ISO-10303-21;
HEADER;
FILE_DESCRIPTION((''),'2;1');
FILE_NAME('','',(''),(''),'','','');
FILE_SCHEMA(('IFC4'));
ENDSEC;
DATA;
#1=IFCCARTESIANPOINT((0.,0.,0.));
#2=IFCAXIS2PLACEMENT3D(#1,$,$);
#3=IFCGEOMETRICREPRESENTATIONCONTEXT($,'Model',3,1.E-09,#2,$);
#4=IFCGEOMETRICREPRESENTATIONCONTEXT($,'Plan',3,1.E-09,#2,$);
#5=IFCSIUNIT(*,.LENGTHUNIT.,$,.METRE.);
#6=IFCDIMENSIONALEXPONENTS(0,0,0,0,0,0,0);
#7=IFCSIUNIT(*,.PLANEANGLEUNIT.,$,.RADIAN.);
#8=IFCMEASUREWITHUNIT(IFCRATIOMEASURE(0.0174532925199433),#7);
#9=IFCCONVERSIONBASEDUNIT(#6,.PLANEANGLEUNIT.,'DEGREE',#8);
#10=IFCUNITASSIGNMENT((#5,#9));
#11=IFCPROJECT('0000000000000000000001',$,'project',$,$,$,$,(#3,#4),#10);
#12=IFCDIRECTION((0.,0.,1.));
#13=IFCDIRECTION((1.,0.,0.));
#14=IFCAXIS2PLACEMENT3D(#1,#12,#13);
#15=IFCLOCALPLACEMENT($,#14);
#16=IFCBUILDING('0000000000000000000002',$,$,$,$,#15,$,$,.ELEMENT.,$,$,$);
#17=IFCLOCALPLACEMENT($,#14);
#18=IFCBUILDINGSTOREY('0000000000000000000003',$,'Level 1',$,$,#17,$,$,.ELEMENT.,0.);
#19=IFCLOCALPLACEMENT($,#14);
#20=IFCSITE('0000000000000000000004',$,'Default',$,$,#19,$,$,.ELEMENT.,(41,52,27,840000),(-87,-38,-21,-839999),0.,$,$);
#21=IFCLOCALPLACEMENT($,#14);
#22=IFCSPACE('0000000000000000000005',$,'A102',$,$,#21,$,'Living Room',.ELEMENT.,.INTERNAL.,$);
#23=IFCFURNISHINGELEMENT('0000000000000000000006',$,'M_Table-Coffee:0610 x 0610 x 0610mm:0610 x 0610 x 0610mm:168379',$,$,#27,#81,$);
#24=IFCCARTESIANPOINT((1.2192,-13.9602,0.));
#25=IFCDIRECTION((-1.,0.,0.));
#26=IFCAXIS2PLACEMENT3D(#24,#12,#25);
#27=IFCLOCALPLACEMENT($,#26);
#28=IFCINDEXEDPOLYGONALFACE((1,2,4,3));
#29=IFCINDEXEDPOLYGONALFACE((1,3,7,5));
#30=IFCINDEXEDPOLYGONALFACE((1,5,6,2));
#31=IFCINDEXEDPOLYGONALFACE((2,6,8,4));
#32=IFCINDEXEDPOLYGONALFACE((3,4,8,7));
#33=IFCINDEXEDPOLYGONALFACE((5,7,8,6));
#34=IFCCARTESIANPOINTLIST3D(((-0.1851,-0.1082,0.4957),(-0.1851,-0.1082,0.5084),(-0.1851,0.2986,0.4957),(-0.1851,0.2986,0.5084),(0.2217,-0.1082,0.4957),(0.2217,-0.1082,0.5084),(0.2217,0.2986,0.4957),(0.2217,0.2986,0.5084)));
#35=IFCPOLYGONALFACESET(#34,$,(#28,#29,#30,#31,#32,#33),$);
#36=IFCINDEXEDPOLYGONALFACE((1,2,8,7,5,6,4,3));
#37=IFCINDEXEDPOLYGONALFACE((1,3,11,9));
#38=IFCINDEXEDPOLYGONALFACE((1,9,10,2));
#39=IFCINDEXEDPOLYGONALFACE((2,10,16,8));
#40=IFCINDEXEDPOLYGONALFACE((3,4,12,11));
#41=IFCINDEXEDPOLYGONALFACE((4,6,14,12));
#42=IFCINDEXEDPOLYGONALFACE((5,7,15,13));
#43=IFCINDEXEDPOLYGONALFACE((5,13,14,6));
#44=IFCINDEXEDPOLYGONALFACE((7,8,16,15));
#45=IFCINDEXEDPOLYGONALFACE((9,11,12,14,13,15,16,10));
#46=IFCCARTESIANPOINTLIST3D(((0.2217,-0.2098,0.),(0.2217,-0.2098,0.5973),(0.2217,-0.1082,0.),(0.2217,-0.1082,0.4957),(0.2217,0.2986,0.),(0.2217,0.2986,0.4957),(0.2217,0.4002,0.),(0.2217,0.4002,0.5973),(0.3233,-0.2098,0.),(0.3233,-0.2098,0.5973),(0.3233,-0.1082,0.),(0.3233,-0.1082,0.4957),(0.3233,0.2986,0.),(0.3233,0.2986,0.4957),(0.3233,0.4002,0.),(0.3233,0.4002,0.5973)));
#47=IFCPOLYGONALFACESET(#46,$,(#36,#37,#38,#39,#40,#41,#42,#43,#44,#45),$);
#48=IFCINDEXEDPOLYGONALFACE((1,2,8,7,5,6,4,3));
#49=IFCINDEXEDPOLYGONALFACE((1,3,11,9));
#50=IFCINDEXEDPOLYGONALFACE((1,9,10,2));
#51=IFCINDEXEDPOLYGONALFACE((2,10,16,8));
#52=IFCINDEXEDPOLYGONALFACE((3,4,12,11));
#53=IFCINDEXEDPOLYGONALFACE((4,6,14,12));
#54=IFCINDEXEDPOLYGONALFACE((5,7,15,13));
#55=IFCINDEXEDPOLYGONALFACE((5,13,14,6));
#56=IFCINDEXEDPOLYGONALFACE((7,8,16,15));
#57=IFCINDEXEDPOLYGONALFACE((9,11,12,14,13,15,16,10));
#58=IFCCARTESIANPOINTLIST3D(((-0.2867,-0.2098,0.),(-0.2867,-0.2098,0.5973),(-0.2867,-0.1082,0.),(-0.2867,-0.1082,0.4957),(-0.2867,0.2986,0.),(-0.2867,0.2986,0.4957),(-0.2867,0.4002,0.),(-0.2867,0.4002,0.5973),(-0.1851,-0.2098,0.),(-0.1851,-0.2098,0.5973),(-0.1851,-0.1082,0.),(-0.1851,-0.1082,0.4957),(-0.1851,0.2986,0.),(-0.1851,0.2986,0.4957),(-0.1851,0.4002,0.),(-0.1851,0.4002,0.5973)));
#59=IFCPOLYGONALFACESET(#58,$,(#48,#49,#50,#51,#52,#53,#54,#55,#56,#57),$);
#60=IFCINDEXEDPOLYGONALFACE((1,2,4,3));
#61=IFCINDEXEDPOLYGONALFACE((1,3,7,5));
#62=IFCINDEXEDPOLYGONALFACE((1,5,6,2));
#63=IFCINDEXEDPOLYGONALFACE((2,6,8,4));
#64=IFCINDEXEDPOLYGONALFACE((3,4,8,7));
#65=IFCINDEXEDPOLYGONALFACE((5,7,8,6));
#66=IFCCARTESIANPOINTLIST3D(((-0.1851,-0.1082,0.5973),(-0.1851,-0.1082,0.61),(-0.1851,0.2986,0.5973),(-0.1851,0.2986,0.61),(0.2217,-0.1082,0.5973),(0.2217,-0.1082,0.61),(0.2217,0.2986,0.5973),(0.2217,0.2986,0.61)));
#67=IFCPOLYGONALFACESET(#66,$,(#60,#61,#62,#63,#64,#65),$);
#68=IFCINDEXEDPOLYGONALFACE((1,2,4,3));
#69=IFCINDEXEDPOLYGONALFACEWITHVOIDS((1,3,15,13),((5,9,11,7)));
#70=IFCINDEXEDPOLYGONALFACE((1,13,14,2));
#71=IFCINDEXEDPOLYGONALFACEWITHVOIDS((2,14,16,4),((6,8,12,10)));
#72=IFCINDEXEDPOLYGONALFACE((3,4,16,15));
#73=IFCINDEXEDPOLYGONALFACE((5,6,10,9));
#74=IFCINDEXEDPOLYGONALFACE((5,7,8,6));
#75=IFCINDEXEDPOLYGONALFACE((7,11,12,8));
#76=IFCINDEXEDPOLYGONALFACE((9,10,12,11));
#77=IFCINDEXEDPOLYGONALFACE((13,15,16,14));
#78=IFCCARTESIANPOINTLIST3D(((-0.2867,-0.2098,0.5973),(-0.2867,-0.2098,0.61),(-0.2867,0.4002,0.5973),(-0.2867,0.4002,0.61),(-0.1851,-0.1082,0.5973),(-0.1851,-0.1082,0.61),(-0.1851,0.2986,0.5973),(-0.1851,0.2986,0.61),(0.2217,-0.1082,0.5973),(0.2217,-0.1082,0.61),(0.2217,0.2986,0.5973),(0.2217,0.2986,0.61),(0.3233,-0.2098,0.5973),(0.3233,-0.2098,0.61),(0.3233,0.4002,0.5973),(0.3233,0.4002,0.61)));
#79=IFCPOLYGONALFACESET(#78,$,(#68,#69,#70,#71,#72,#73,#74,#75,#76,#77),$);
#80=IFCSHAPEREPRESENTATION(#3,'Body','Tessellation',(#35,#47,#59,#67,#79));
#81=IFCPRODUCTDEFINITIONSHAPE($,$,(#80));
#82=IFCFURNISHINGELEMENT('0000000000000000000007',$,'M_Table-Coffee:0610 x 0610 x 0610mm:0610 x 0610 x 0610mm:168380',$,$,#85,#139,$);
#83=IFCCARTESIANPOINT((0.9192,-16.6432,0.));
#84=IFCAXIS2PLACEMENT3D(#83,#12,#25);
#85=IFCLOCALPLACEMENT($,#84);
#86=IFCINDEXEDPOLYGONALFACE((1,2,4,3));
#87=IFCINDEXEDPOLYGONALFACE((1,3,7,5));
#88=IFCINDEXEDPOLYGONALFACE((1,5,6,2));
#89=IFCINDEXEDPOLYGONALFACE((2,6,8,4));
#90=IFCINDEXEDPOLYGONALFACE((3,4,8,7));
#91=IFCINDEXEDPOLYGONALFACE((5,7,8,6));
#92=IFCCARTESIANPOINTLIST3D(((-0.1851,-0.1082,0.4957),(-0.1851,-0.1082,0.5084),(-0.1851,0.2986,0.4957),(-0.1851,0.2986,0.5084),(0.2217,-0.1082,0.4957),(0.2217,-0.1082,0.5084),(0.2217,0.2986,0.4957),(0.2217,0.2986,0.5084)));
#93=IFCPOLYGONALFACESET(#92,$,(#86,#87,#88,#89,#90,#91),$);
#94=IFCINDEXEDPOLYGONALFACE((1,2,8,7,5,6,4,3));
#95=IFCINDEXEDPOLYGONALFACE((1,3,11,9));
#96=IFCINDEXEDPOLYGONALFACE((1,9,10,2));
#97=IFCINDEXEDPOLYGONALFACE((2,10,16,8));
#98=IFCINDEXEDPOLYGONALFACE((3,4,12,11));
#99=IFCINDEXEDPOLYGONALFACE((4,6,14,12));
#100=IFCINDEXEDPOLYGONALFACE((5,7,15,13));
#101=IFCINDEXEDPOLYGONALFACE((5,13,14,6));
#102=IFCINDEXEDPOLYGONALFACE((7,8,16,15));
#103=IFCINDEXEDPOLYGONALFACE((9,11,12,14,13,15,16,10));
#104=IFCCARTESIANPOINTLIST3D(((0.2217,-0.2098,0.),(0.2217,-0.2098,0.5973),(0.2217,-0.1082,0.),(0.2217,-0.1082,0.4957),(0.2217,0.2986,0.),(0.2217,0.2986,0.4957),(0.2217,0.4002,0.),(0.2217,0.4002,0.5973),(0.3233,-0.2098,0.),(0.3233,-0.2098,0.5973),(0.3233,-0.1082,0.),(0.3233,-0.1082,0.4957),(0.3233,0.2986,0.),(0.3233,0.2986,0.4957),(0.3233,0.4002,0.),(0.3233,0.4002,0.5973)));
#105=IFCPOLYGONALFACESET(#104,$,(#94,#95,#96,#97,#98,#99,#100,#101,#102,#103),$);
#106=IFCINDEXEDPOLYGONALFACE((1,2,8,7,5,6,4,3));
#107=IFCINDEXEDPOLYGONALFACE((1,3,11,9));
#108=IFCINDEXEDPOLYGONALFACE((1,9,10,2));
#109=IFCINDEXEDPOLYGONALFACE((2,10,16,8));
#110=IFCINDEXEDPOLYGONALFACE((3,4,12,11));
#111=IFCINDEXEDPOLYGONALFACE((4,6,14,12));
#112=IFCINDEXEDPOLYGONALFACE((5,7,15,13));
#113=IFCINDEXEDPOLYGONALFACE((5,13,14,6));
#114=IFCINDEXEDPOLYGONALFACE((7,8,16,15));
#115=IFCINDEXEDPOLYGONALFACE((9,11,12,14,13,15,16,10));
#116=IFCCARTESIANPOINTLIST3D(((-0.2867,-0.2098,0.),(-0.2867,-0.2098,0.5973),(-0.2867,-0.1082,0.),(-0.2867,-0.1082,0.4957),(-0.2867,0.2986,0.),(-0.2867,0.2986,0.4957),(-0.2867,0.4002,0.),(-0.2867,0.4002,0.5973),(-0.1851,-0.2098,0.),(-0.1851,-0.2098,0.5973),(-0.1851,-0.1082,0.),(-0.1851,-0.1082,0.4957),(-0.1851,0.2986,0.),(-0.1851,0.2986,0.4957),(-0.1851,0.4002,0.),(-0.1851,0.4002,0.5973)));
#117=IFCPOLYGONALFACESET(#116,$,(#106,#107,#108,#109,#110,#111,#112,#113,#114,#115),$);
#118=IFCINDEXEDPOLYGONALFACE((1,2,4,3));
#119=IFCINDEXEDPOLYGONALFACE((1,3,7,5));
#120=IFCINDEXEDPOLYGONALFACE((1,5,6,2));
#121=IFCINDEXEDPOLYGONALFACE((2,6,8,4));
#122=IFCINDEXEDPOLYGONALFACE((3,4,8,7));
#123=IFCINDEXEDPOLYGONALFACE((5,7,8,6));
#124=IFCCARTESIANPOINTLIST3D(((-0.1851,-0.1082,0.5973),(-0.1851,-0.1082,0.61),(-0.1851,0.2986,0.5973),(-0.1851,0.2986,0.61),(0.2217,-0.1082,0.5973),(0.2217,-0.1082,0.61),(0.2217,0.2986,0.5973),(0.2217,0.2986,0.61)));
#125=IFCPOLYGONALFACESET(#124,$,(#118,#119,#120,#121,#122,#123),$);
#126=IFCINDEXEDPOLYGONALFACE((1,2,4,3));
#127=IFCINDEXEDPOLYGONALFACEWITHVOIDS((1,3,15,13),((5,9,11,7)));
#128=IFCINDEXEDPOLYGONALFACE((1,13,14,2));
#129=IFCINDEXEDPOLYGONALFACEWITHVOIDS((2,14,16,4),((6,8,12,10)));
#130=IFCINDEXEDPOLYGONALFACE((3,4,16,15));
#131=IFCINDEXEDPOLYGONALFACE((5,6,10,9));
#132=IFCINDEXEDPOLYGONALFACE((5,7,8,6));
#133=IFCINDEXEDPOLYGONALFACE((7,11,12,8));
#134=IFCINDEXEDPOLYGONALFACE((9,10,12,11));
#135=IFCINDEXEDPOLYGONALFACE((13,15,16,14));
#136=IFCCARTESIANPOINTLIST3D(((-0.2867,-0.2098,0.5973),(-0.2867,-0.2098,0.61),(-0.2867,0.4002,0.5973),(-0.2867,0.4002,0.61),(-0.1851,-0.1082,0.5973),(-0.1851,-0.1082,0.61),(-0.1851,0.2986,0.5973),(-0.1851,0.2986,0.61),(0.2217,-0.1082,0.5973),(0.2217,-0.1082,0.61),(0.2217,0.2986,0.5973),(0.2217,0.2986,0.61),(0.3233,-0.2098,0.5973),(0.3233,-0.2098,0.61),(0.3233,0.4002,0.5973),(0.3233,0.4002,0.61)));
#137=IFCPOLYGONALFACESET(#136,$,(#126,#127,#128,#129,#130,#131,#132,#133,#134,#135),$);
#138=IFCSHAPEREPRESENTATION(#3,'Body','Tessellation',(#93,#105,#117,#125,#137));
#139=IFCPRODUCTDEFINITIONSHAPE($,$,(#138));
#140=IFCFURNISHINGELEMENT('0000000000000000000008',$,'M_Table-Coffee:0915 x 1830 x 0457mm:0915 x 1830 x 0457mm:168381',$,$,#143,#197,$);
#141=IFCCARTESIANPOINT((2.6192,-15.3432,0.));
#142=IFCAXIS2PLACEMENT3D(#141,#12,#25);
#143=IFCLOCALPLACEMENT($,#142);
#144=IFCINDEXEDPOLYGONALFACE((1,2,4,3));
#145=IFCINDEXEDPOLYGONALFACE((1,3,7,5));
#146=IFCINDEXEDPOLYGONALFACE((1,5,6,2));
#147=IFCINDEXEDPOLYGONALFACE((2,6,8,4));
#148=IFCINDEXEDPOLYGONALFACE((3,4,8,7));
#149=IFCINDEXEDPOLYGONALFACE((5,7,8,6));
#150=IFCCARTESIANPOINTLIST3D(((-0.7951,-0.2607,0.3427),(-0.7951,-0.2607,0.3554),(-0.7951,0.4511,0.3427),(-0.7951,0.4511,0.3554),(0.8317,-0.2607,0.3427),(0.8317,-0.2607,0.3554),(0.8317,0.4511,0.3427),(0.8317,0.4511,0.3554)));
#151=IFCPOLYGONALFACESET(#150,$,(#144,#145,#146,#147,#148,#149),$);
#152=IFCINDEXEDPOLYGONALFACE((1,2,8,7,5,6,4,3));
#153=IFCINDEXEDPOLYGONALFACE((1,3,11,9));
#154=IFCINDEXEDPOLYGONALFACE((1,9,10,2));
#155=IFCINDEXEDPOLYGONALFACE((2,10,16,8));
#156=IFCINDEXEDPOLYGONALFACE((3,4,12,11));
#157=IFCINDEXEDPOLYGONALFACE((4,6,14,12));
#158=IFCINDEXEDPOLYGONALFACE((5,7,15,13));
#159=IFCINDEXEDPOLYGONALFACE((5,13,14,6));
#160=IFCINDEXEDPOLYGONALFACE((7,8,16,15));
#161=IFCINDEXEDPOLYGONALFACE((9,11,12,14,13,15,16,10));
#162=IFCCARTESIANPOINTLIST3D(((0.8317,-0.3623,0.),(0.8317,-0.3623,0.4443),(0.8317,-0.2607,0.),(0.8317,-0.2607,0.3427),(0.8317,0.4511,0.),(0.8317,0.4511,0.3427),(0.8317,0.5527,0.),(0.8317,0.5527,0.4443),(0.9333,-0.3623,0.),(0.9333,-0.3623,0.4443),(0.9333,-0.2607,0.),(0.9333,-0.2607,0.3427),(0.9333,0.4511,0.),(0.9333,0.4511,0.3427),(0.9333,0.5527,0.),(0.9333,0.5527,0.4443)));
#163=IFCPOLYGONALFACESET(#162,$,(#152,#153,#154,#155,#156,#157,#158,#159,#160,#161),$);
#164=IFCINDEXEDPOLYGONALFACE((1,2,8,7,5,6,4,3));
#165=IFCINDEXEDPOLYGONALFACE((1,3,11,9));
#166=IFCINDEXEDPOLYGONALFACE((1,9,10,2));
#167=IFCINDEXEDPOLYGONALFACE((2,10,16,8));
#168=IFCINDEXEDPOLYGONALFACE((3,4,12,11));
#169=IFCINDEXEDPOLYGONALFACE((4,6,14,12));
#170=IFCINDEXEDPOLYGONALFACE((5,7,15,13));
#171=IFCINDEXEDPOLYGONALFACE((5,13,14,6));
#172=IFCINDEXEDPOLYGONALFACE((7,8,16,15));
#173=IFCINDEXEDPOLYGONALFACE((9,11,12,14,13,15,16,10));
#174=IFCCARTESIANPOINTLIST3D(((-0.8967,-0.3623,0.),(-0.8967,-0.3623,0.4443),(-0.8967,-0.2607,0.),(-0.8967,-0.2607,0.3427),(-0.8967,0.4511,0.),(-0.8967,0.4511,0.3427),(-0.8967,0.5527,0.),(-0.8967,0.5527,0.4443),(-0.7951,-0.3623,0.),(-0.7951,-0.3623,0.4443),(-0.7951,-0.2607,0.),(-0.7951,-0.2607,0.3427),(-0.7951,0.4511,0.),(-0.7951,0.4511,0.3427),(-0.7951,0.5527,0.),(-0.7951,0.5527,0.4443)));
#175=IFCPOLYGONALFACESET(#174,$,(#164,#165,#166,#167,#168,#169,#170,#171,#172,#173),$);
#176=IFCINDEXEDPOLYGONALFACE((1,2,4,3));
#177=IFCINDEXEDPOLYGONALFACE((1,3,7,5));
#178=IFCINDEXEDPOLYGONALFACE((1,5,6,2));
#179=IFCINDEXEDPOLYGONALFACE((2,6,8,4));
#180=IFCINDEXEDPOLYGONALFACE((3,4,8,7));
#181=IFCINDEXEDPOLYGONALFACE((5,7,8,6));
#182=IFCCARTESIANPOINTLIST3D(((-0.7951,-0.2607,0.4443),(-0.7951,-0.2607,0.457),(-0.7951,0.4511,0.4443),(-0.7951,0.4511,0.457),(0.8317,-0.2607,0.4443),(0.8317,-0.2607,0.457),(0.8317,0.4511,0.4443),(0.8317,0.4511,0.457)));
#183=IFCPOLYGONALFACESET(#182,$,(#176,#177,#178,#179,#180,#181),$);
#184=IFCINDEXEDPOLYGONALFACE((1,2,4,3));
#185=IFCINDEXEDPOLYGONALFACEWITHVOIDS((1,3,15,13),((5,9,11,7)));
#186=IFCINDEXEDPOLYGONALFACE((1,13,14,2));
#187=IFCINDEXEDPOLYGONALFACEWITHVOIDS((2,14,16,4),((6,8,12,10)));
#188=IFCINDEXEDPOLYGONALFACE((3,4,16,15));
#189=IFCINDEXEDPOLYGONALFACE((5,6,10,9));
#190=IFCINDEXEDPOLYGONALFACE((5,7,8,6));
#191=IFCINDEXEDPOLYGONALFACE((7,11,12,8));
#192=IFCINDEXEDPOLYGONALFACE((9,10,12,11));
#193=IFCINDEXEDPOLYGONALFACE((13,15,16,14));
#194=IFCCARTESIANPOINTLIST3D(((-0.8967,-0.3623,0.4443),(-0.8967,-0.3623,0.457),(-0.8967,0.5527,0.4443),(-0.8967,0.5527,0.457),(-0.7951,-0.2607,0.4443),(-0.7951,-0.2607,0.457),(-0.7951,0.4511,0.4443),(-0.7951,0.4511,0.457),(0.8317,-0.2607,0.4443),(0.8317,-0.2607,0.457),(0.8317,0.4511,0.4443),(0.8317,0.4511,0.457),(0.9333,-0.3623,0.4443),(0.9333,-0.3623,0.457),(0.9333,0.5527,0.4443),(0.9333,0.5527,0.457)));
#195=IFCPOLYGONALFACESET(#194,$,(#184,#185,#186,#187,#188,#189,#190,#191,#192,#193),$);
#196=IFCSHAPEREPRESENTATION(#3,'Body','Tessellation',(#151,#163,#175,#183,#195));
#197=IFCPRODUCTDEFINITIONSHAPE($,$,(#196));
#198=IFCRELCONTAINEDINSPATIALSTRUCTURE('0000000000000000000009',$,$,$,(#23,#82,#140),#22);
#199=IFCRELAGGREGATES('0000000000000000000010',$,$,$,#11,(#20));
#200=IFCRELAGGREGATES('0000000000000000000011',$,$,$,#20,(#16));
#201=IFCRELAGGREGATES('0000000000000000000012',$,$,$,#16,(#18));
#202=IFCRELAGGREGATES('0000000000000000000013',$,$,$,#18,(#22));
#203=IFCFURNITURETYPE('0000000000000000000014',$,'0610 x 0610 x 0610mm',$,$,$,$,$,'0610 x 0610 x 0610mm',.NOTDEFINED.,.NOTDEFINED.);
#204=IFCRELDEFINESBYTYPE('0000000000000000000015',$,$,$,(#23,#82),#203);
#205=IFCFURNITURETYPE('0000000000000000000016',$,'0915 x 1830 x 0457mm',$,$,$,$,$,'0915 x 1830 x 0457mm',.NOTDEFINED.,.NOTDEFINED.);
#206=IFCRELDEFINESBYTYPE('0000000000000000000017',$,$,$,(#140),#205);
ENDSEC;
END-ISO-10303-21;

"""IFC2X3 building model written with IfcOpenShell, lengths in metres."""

from ifc_helpers import new_model, entity, si_unit, converted_unit, frame, origin, origin_with_axes, origin_2d_with_axis, place, context, project, spatial, polyline, rectangle, outline, extrude, source, transform, mapped, type_object, type_shapes, element, save


model = new_model("IFC2X3")

# Units and contexts
model_context = context("Model", 3, precision=1e-09, world=origin())
plan_context = context("Plan", 3, precision=1e-09, world=origin())
ifc_project = project(units=[si_unit("LENGTHUNIT", "METRE"), converted_unit("PLANEANGLEUNIT", "DEGREE", entity("IfcRatioMeasure", 0.0174532925199433), si_unit("PLANEANGLEUNIT", "RADIAN"), dimensions=[0, 0, 0, 0, 0, 0, 0])], contexts=[model_context, plan_context])

# Site, building, storey, space
site_placement = place(None, origin_with_axes())
site = spatial("IfcSite", under=ifc_project, at=site_placement, Name="Default", CompositionType="ELEMENT", RefLatitude=(41, 52, 27, 840000), RefLongitude=(-87, -38, -21, -839999), RefElevation=0.0)
building_placement = place(None, origin_with_axes())
building = spatial("IfcBuilding", under=site, at=building_placement, CompositionType="ELEMENT")
storey_placement = place(None, origin_with_axes())
storey = spatial("IfcBuildingStorey", under=building, at=storey_placement, Name="Level 1", CompositionType="ELEMENT", Elevation=0.0)
space_placement = place(None, origin_with_axes())
space = spatial("IfcSpace", under=storey, at=space_placement, Name="A102", LongName="Living Room", CompositionType="ELEMENT", InteriorOrExteriorSpace="INTERNAL")

# Furnishing elements
furniture_type_1 = type_object("IfcFurnitureType", Name="0610 x 0610 x 0610mm", ElementType="0610 x 0610 x 0610mm", AssemblyPlace="NOTDEFINED")
shared_shape_1 = source(origin(), model_context, "Body", "SweptSolid", [
    extrude(rectangle(XDim=0.4068, YDim=0.4068, at=origin_2d_with_axis()), frame((0.0183, 0.0952, 0.4957), z_axis=(0.0, 0.0, 1.0), x_axis=(-1.0, 0.0, 0.0)), (0.0, 0.0, 1.0), 0.0127),
    extrude(outline(polyline([(-0.2732, -0.305), (0.324, -0.305), (0.324, 0.305), (-0.2732, 0.305), (-0.2732, 0.2034), (0.2225, 0.2034), (0.2225, -0.2034), (-0.2732, -0.2034), (-0.2732, -0.305)])), frame((0.2217, 0.0952, 0.2732), z_axis=(1.0, 0.0, 0.0), x_axis=(0.0, 0.0, 1.0)), (0.0, 0.0, 1.0), 0.1016),
    extrude(outline(polyline([(-0.305, -0.3241), (0.305, -0.3241), (0.305, 0.2733), (0.2034, 0.2733), (0.2034, -0.2224), (-0.2034, -0.2224), (-0.2034, 0.2733), (-0.305, 0.2733), (-0.305, -0.3241)])), frame((-0.2867, 0.0952, 0.2733), z_axis=(1.0, 0.0, 0.0), x_axis=(0.0, -1.0, 0.0)), (0.0, 0.0, 1.0), 0.1016),
    extrude(rectangle(XDim=0.4068, YDim=0.4068, at=origin_2d_with_axis()), frame((0.0183, 0.0952, 0.5973), z_axis=(0.0, 0.0, 1.0), x_axis=(-1.0, 0.0, 0.0)), (0.0, 0.0, 1.0), 0.0127),
    extrude(outline(polyline([(-0.305, -0.305), (0.305, -0.305), (0.305, 0.305), (-0.305, 0.305), (-0.305, -0.305)]), holes=[polyline([(-0.2034, -0.2034), (-0.2034, 0.2034), (0.2034, 0.2034), (0.2034, -0.2034), (-0.2034, -0.2034)])]), frame((0.0183, 0.0952, 0.5973), z_axis=(0.0, 0.0, 1.0), x_axis=(-1.0, 0.0, 0.0)), (0.0, 0.0, 1.0), 0.0127),
])
type_shapes(furniture_type_1, [shared_shape_1])
for number, where, z_axis, x_axis, name in (
    (1, (1.2192, -13.9602, 0.0), (0.0, 0.0, 1.0), (-1.0, 0.0, 0.0), "M_Table-Coffee:0610 x 0610 x 0610mm:0610 x 0610 x 0610mm:168379"),
    (2, (0.9192, -16.6432, 0.0), (0.0, 0.0, 1.0), (-1.0, 0.0, 0.0), "M_Table-Coffee:0610 x 0610 x 0610mm:0610 x 0610 x 0610mm:168380"),
):
    element("IfcFurnishingElement", number, at=place(None, frame(where, z_axis=z_axis, x_axis=x_axis)), inside=space, type_object=furniture_type_1, Name=name, context=model_context, shape_type="MappedRepresentation", body=[
        mapped(shared_shape_1, transform((0.0, 0.0, 0.0), scale=1.0)),
    ])
furniture_type_2 = type_object("IfcFurnitureType", Name="0915 x 1830 x 0457mm", ElementType="0915 x 1830 x 0457mm", AssemblyPlace="NOTDEFINED")
shared_shape_2 = source(origin(), model_context, "Body", "SweptSolid", [
    extrude(rectangle(XDim=1.6268, YDim=0.7118, at=origin_2d_with_axis()), frame((0.0183, 0.0952, 0.3427), z_axis=(0.0, 0.0, 1.0), x_axis=(-1.0, 0.0, 0.0)), (0.0, 0.0, 1.0), 0.0127),
    extrude(outline(polyline([(-0.1967, -0.4575), (0.2475, -0.4575), (0.2475, 0.4575), (-0.1967, 0.4575), (-0.1967, 0.3559), (0.146, 0.3559), (0.146, -0.3559), (-0.1967, -0.3559), (-0.1967, -0.4575)])), frame((0.8317, 0.0952, 0.1967), z_axis=(1.0, 0.0, 0.0), x_axis=(0.0, 0.0, 1.0)), (0.0, 0.0, 1.0), 0.1016),
    extrude(outline(polyline([(-0.4575, -0.2476), (0.4575, -0.2476), (0.4575, 0.1968), (0.3559, 0.1968), (0.3559, -0.1459), (-0.3559, -0.1459), (-0.3559, 0.1968), (-0.4575, 0.1968), (-0.4575, -0.2476)])), frame((-0.8967, 0.0952, 0.1968), z_axis=(1.0, 0.0, 0.0), x_axis=(0.0, -1.0, 0.0)), (0.0, 0.0, 1.0), 0.1016),
    extrude(rectangle(XDim=1.6268, YDim=0.7118, at=origin_2d_with_axis()), frame((0.0183, 0.0952, 0.4443), z_axis=(0.0, 0.0, 1.0), x_axis=(-1.0, 0.0, 0.0)), (0.0, 0.0, 1.0), 0.0127),
    extrude(outline(polyline([(-0.915, -0.4575), (0.915, -0.4575), (0.915, 0.4575), (-0.915, 0.4575), (-0.915, -0.4575)]), holes=[polyline([(-0.8134, -0.3559), (-0.8134, 0.3559), (0.8134, 0.3559), (0.8134, -0.3559), (-0.8134, -0.3559)])]), frame((0.0183, 0.0952, 0.4443), z_axis=(0.0, 0.0, 1.0), x_axis=(-1.0, 0.0, 0.0)), (0.0, 0.0, 1.0), 0.0127),
])
type_shapes(furniture_type_2, [shared_shape_2])
furnishing_placement = place(None, frame((2.6192, -15.3432, 0.0), z_axis=(0.0, 0.0, 1.0), x_axis=(-1.0, 0.0, 0.0)))
element("IfcFurnishingElement", 3, at=furnishing_placement, inside=space, type_object=furniture_type_2, Name="M_Table-Coffee:0915 x 1830 x 0457mm:0915 x 1830 x 0457mm:168381", context=model_context, shape_type="MappedRepresentation", body=[
    mapped(shared_shape_2, transform((0.0, 0.0, 0.0), scale=1.0)),
])

save(model, "model.ifc")
